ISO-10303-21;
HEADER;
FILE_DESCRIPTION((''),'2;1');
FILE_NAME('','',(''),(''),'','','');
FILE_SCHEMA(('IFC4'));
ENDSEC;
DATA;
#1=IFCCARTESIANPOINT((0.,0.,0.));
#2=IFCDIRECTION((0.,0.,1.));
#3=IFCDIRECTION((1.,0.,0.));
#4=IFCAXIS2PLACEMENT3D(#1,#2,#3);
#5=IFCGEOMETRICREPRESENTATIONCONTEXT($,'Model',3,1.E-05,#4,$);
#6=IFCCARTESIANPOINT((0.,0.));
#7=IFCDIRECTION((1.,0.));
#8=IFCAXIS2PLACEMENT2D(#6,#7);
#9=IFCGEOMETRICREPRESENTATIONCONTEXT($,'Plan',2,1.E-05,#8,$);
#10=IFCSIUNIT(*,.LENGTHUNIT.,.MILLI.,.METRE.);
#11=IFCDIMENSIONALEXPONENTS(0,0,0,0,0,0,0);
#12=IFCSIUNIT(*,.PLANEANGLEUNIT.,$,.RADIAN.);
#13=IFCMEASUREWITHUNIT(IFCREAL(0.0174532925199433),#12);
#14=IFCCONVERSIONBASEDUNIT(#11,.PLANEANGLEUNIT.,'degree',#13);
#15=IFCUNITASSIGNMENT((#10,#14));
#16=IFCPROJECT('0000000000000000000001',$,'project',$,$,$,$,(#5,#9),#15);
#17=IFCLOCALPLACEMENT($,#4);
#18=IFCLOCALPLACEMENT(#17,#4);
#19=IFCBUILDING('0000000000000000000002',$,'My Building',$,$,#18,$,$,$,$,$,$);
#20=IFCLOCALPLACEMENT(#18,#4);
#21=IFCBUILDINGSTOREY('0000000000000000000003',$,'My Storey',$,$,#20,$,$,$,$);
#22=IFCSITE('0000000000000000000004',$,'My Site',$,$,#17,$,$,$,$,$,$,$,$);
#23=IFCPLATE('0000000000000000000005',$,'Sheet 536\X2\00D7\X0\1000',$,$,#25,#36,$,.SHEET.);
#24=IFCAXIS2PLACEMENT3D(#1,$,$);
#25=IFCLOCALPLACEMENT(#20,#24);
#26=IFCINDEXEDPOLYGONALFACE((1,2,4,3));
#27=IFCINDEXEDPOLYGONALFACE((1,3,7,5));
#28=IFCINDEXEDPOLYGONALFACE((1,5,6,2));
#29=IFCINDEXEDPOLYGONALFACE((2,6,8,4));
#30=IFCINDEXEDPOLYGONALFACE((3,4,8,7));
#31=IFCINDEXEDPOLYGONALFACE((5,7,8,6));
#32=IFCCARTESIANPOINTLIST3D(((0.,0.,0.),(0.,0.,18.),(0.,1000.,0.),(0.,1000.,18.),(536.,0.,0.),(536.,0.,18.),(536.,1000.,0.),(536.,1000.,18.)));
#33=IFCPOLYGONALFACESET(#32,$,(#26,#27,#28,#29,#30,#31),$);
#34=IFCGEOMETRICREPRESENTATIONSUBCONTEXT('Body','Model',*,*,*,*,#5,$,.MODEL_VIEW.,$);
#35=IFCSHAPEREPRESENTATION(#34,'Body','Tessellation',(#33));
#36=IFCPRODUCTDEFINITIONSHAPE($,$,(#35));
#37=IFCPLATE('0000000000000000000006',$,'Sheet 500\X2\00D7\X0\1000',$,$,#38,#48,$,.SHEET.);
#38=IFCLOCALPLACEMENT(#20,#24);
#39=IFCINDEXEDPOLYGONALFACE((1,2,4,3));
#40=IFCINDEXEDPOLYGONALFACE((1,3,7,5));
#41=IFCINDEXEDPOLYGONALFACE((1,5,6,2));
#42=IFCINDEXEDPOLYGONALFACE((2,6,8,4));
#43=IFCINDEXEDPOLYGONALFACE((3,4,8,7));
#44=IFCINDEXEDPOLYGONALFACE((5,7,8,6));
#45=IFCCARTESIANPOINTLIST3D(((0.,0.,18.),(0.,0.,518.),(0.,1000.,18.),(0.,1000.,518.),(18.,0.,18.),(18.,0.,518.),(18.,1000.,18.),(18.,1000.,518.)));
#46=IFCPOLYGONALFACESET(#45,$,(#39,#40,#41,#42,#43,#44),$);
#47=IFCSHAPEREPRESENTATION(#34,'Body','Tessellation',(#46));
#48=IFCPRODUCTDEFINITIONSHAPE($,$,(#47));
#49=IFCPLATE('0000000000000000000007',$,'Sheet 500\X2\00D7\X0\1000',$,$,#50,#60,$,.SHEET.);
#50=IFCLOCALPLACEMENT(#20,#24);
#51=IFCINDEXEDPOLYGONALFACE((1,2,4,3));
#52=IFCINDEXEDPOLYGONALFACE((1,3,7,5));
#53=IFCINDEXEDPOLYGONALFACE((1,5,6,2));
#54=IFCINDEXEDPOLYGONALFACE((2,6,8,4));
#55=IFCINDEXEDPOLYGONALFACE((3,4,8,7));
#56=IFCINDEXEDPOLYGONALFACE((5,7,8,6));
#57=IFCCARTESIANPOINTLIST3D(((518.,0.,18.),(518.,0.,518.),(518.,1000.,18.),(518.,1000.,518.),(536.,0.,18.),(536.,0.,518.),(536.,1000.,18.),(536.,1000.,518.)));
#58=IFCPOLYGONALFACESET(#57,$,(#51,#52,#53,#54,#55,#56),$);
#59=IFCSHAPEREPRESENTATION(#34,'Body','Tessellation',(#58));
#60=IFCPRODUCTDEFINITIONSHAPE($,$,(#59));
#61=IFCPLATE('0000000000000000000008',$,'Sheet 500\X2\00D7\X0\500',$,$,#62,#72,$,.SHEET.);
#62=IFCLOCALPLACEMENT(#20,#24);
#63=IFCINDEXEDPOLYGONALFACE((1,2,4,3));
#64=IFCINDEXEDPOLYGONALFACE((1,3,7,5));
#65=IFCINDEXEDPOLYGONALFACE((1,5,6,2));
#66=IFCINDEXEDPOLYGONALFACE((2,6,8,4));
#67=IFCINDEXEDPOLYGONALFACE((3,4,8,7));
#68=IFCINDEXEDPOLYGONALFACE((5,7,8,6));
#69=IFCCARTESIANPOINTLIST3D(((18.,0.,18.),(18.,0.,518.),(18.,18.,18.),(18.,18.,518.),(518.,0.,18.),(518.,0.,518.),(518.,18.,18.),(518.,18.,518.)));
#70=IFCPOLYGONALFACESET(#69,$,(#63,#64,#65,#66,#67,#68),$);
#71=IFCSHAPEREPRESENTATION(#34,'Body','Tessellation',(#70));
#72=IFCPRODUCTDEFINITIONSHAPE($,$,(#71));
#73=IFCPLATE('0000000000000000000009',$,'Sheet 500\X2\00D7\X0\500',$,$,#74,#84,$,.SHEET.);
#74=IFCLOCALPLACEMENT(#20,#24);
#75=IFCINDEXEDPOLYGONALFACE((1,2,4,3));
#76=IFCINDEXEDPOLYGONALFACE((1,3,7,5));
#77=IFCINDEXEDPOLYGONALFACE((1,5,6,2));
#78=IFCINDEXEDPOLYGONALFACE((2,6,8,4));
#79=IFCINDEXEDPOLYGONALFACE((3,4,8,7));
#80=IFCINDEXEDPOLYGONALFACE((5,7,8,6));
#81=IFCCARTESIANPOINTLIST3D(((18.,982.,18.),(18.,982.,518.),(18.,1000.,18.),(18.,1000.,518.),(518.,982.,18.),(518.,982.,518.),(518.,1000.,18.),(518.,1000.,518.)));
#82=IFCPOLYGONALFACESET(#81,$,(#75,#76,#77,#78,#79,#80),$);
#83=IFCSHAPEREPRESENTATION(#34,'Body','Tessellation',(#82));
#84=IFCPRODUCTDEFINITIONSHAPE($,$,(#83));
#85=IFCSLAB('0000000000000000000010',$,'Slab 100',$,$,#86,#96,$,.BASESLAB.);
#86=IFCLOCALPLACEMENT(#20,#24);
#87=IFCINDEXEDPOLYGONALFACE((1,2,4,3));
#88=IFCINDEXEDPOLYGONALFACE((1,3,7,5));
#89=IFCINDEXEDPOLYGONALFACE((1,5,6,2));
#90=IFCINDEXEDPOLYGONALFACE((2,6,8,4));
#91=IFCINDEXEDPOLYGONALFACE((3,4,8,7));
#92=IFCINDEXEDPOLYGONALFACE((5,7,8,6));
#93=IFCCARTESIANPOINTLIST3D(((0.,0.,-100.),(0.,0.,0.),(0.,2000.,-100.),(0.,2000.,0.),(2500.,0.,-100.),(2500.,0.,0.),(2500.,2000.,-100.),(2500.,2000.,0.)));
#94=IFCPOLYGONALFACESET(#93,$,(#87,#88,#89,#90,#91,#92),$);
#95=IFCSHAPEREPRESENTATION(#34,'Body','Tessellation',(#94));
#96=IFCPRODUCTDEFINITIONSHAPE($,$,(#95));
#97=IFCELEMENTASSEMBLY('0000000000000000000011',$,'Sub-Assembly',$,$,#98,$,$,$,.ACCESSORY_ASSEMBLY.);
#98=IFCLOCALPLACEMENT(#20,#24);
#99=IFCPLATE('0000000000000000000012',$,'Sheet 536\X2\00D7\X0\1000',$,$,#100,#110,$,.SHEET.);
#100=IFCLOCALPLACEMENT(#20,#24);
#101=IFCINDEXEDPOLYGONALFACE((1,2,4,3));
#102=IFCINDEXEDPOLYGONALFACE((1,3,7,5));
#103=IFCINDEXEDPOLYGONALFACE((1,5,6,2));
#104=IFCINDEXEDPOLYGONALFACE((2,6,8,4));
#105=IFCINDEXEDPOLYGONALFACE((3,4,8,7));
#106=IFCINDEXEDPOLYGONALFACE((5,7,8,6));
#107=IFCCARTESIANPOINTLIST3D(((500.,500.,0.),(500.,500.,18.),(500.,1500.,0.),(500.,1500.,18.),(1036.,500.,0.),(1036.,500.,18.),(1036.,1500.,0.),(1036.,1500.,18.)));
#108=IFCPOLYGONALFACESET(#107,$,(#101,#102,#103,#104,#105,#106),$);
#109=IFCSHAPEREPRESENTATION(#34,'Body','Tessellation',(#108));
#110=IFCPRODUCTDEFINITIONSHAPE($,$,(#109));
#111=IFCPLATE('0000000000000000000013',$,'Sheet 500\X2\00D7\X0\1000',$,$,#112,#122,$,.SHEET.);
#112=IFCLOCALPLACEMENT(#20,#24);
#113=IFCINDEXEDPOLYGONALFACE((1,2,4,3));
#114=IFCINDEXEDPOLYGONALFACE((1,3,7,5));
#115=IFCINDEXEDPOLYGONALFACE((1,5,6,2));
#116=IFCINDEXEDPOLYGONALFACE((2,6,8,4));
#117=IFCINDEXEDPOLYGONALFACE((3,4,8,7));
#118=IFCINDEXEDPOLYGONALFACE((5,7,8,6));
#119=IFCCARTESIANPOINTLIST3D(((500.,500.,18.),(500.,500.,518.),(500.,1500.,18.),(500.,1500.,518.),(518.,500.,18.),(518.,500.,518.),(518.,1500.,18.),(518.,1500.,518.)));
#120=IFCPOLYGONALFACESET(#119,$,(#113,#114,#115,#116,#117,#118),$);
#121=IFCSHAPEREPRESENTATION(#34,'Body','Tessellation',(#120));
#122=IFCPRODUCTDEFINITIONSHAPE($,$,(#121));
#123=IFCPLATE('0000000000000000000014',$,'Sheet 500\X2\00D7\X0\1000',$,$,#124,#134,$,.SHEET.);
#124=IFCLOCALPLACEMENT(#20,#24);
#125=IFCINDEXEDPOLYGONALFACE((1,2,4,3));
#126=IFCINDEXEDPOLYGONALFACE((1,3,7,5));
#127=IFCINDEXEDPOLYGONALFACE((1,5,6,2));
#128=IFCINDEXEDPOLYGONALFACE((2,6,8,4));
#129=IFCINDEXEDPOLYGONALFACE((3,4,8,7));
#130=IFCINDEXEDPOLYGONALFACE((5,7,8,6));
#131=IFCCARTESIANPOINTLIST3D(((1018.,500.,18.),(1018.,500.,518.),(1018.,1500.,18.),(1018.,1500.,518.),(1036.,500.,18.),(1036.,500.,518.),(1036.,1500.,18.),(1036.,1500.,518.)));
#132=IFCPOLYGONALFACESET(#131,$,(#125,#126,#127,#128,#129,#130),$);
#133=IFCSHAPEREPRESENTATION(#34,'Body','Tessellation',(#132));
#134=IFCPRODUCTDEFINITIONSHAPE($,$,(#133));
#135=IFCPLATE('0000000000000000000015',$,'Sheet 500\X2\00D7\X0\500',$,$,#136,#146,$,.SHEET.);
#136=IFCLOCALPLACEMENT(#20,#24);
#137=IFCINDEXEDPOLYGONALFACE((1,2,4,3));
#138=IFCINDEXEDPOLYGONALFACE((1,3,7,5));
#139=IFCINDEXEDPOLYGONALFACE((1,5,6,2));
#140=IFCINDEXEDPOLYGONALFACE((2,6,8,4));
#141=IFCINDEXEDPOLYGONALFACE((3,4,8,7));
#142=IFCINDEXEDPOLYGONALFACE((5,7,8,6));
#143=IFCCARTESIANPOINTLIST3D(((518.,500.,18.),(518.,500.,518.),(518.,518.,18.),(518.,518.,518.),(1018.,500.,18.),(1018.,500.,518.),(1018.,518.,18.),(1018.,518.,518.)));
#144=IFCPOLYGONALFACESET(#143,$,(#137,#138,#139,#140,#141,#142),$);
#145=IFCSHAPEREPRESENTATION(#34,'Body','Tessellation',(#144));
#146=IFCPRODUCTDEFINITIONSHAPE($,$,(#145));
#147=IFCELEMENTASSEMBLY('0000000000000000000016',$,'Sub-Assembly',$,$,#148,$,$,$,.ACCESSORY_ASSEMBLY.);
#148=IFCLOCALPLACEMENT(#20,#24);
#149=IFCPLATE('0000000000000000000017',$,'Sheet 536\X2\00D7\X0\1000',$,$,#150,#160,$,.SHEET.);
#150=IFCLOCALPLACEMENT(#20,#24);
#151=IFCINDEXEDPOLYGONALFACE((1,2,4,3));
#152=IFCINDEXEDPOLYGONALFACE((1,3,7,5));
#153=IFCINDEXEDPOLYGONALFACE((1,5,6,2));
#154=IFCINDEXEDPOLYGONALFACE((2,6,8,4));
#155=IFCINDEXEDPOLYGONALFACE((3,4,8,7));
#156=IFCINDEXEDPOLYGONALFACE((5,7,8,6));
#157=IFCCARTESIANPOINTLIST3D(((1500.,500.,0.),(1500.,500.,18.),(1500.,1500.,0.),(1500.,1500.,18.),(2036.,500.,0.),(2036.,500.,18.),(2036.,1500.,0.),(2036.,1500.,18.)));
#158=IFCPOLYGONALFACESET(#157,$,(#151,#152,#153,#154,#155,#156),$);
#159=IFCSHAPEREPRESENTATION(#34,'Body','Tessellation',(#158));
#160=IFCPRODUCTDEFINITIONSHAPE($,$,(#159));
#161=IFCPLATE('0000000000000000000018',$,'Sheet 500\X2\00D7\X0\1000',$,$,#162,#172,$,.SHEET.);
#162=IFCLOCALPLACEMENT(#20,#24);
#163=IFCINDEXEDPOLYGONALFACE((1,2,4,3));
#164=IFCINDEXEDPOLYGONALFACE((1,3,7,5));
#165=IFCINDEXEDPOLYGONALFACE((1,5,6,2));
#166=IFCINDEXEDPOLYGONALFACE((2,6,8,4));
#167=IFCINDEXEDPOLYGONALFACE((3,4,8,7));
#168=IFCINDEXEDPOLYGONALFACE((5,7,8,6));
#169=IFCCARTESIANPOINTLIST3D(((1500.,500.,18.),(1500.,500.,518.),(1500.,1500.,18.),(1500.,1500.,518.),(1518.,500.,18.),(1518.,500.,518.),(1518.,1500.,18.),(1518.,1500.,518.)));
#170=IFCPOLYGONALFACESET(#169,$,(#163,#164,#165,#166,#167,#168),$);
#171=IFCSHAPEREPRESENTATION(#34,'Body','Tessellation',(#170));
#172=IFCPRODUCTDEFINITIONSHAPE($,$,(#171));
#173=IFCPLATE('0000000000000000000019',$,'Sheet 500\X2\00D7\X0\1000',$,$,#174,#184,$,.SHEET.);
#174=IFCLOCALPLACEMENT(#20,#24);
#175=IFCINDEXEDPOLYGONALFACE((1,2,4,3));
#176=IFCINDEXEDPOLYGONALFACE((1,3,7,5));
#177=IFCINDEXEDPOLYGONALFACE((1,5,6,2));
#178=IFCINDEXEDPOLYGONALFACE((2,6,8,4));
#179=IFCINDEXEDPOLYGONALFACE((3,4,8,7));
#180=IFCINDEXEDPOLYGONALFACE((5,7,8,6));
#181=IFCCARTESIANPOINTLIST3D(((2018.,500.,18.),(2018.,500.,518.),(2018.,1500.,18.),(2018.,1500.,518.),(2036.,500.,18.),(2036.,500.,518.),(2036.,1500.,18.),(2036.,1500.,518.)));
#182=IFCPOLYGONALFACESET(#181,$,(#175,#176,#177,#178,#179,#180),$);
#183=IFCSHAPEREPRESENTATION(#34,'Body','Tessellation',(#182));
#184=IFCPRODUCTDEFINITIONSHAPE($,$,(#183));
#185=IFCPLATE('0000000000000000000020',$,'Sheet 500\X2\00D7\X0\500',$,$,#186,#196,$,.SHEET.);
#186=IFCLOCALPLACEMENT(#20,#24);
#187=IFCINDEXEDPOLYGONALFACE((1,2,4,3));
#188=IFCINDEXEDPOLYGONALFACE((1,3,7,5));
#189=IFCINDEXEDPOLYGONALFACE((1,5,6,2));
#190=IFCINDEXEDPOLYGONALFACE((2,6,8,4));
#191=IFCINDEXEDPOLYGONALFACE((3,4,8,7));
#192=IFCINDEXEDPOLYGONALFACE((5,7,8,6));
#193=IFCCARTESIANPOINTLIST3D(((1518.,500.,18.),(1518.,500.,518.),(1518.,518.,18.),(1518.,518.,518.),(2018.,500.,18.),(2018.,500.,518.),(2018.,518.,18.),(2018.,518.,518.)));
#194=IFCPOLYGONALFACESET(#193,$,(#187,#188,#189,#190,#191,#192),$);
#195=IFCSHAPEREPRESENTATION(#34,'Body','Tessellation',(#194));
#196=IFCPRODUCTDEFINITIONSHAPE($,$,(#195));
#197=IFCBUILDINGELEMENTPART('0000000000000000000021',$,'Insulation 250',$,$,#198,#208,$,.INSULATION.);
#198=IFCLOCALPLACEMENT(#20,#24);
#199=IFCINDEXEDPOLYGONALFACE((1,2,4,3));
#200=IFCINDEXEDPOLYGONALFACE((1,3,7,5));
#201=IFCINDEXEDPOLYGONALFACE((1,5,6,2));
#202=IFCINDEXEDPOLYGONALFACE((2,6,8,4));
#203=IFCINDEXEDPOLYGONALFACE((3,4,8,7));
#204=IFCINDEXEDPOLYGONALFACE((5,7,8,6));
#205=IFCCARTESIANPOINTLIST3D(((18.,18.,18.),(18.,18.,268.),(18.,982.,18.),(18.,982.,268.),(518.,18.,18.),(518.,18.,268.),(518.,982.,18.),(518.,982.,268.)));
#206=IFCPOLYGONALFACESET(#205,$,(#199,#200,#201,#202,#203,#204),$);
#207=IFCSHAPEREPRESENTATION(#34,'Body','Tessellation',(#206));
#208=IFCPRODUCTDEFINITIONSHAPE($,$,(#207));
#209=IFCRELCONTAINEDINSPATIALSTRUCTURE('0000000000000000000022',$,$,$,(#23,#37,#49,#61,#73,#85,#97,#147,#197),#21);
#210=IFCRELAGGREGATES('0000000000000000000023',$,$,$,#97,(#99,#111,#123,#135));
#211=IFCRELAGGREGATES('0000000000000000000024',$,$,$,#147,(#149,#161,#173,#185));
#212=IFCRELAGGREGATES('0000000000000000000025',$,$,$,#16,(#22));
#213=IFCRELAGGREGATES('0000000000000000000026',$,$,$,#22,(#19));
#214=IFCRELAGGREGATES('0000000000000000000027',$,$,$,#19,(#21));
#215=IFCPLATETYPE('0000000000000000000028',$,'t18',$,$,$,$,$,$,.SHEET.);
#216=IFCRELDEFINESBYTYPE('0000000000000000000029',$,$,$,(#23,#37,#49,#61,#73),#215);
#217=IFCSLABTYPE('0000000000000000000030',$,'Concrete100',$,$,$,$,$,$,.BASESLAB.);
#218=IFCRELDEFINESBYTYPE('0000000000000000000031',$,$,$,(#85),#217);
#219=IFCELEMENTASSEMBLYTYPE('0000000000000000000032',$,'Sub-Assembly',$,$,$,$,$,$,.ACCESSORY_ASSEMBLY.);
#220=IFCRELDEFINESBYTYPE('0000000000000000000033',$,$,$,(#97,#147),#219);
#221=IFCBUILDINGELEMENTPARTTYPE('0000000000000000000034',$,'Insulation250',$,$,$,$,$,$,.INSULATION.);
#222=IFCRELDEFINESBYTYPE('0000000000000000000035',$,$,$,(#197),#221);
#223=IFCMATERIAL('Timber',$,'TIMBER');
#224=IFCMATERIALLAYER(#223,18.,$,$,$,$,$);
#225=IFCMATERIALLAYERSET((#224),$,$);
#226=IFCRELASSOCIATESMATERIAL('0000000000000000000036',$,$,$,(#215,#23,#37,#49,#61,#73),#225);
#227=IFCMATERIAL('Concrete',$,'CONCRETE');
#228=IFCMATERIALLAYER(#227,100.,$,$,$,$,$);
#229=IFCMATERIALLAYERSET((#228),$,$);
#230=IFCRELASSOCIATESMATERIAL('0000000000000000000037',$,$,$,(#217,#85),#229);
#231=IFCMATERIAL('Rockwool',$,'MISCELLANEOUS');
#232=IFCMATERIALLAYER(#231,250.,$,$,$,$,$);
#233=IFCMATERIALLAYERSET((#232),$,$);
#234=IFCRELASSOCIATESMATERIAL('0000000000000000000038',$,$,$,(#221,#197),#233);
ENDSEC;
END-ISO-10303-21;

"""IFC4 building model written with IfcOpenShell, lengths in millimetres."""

from ifc_helpers import new_model, entity, si_unit, converted_unit, frame, origin_with_axes, origin_2d_with_axis, place, context, subcontext, project, spatial, rectangle, extrude, material, layer, layer_set, layer_usage, type_object, element, aggregate, save


model = new_model("IFC4")

# Units and contexts
model_context = context("Model", 3, precision=1e-05, world=origin_with_axes())
plan_context = context("Plan", 2, precision=1e-05, world=origin_2d_with_axis())
body_context = subcontext(model_context, "Body", "Model", "MODEL_VIEW")
ifc_project = project(units=[si_unit("LENGTHUNIT", "METRE", prefix="MILLI"), converted_unit("PLANEANGLEUNIT", "degree", entity("IfcReal", 0.0174532925199433), si_unit("PLANEANGLEUNIT", "RADIAN"), dimensions=[0, 0, 0, 0, 0, 0, 0])], contexts=[model_context, plan_context])

# Site, building, storey
site_placement = place(None, origin_with_axes())
site = spatial("IfcSite", under=ifc_project, at=site_placement, Name="My Site")
building_placement = place(site_placement, origin_with_axes())
building = spatial("IfcBuilding", under=site, at=building_placement, Name="My Building")
storey_placement = place(building_placement, origin_with_axes())
storey = spatial("IfcBuildingStorey", under=building, at=storey_placement, Name="My Storey")

# Plates
ifc_material_1 = material(Name="Timber", Category="TIMBER")
ifc_layer_1 = layer(ifc_material_1, 18.0)
ifc_layer_set_1 = layer_set([ifc_layer_1])
ifc_layer_usage_1 = layer_usage(ifc_layer_set_1, "AXIS3", "POSITIVE", 0.0)
plate_type = type_object("IfcPlateType", Name="t18", PredefinedType="SHEET", material=ifc_layer_set_1)
plate_1_placement = place(storey_placement, frame((268.0, 500.0, 0.0), z_axis=(0.0, 0.0, 1.0), x_axis=(1.0, 0.0, 0.0)))
element("IfcPlate", 1, at=plate_1_placement, inside=storey, type_object=plate_type, material=ifc_layer_usage_1, Name="Sheet 536×1000", PredefinedType="SHEET", context=body_context, shape_type="SweptSolid", body=[
    extrude(rectangle(XDim=536.0, YDim=1000.0), None, (0.0, 0.0, 1.0), 18.0),
])
for number, where, z_axis, x_axis, name in (
    (2, (0.0, 500.0, 268.0), (1.0, 0.0, 0.0), (0.0, 0.0, 1.0), "Sheet 500×1000"),
    (3, (518.0, 500.0, 268.0), (1.0, 0.0, 0.0), (0.0, 0.0, 1.0), "Sheet 500×1000"),
):
    element("IfcPlate", number, at=place(storey_placement, frame(where, z_axis=z_axis, x_axis=x_axis)), inside=storey, type_object=plate_type, material=ifc_layer_usage_1, Name=name, PredefinedType="SHEET", context=body_context, shape_type="SweptSolid", body=[
        extrude(rectangle(XDim=500.0, YDim=1000.0), None, (0.0, 0.0, 1.0), 18.0),
    ])
for number, where, z_axis, x_axis, name in (
    (4, (268.0, 0.0, 268.0), (0.0, 1.0, 0.0), (0.0, 0.0, 1.0), "Sheet 500×500"),
    (5, (268.0, 982.0, 268.0), (0.0, 1.0, 0.0), (0.0, 0.0, 1.0), "Sheet 500×500"),
):
    element("IfcPlate", number, at=place(storey_placement, frame(where, z_axis=z_axis, x_axis=x_axis)), inside=storey, type_object=plate_type, material=ifc_layer_usage_1, Name=name, PredefinedType="SHEET", context=body_context, shape_type="SweptSolid", body=[
        extrude(rectangle(XDim=500.0, YDim=500.0), None, (0.0, 0.0, 1.0), 18.0),
    ])

# Slab
ifc_material_2 = material(Name="Concrete", Category="CONCRETE")
ifc_layer_2 = layer(ifc_material_2, 100.0)
ifc_layer_set_2 = layer_set([ifc_layer_2])
ifc_layer_usage_2 = layer_usage(ifc_layer_set_2, "AXIS3", "POSITIVE", 0.0)
slab_type = type_object("IfcSlabType", Name="Concrete100", PredefinedType="BASESLAB", material=ifc_layer_set_2)
slab_1_placement = place(storey_placement, frame((1250.0, 1000.0, -100.0), z_axis=(0.0, 0.0, 1.0), x_axis=(1.0, 0.0, 0.0)))
element("IfcSlab", 6, at=slab_1_placement, inside=storey, type_object=slab_type, material=ifc_layer_usage_2, Name="Slab 100", PredefinedType="BASESLAB", context=body_context, shape_type="SweptSolid", body=[
    extrude(rectangle(XDim=2500.0, YDim=2000.0), None, (0.0, 0.0, 1.0), 100.0),
])

# Element assemblies, plates
element_assembly_type_1 = type_object("IfcElementAssemblyType", Name="Sub-Assembly", PredefinedType="ACCESSORY_ASSEMBLY")
assembly_1_placement = place(storey_placement, frame((500.0, 500.0, 0.0)))
assembly_1 = element("IfcElementAssembly", 7, at=assembly_1_placement, inside=storey, type_object=element_assembly_type_1, Name="Sub-Assembly", PredefinedType="ACCESSORY_ASSEMBLY")
plate_2_placement = place(assembly_1_placement, frame((268.0, 500.0, 0.0), z_axis=(0.0, 0.0, 1.0), x_axis=(1.0, 0.0, 0.0)))
plate_2 = element("IfcPlate", 8, at=plate_2_placement, Name="Sheet 536×1000", PredefinedType="SHEET", context=body_context, shape_type="SweptSolid", body=[
    extrude(rectangle(XDim=536.0, YDim=1000.0), None, (0.0, 0.0, 1.0), 18.0),
])
plate_3_placement = place(assembly_1_placement, frame((0.0, 500.0, 268.0), z_axis=(1.0, 0.0, 0.0), x_axis=(0.0, 0.0, 1.0)))
plate_3 = element("IfcPlate", 9, at=plate_3_placement, Name="Sheet 500×1000", PredefinedType="SHEET", context=body_context, shape_type="SweptSolid", body=[
    extrude(rectangle(XDim=500.0, YDim=1000.0), None, (0.0, 0.0, 1.0), 18.0),
])
plate_4_placement = place(assembly_1_placement, frame((518.0, 500.0, 268.0), z_axis=(1.0, 0.0, 0.0), x_axis=(0.0, 0.0, 1.0)))
plate_4 = element("IfcPlate", 10, at=plate_4_placement, Name="Sheet 500×1000", PredefinedType="SHEET", context=body_context, shape_type="SweptSolid", body=[
    extrude(rectangle(XDim=500.0, YDim=1000.0), None, (0.0, 0.0, 1.0), 18.0),
])
plate_5_placement = place(assembly_1_placement, frame((268.0, 0.0, 268.0), z_axis=(0.0, 1.0, 0.0), x_axis=(0.0, 0.0, 1.0)))
plate_5 = element("IfcPlate", 11, at=plate_5_placement, Name="Sheet 500×500", PredefinedType="SHEET", context=body_context, shape_type="SweptSolid", body=[
    extrude(rectangle(XDim=500.0, YDim=500.0), None, (0.0, 0.0, 1.0), 18.0),
])
assembly_2_placement = place(storey_placement, frame((1500.0, 500.0, 0.0)))
assembly_2 = element("IfcElementAssembly", 12, at=assembly_2_placement, inside=storey, type_object=element_assembly_type_1, Name="Sub-Assembly", PredefinedType="ACCESSORY_ASSEMBLY")
plate_6_placement = place(assembly_2_placement, frame((268.0, 500.0, 0.0), z_axis=(0.0, 0.0, 1.0), x_axis=(1.0, 0.0, 0.0)))
plate_6 = element("IfcPlate", 13, at=plate_6_placement, Name="Sheet 536×1000", PredefinedType="SHEET", context=body_context, shape_type="SweptSolid", body=[
    extrude(rectangle(XDim=536.0, YDim=1000.0), None, (0.0, 0.0, 1.0), 18.0),
])
plate_7_placement = place(assembly_2_placement, frame((0.0, 500.0, 268.0), z_axis=(1.0, 0.0, 0.0), x_axis=(0.0, 0.0, 1.0)))
plate_7 = element("IfcPlate", 14, at=plate_7_placement, Name="Sheet 500×1000", PredefinedType="SHEET", context=body_context, shape_type="SweptSolid", body=[
    extrude(rectangle(XDim=500.0, YDim=1000.0), None, (0.0, 0.0, 1.0), 18.0),
])
plate_8_placement = place(assembly_2_placement, frame((518.0, 500.0, 268.0), z_axis=(1.0, 0.0, 0.0), x_axis=(0.0, 0.0, 1.0)))
plate_8 = element("IfcPlate", 15, at=plate_8_placement, Name="Sheet 500×1000", PredefinedType="SHEET", context=body_context, shape_type="SweptSolid", body=[
    extrude(rectangle(XDim=500.0, YDim=1000.0), None, (0.0, 0.0, 1.0), 18.0),
])
plate_9_placement = place(assembly_2_placement, frame((268.0, 0.0, 268.0), z_axis=(0.0, 1.0, 0.0), x_axis=(0.0, 0.0, 1.0)))
plate_9 = element("IfcPlate", 16, at=plate_9_placement, Name="Sheet 500×500", PredefinedType="SHEET", context=body_context, shape_type="SweptSolid", body=[
    extrude(rectangle(XDim=500.0, YDim=500.0), None, (0.0, 0.0, 1.0), 18.0),
])

# Building element part
ifc_material_3 = material(Name="Rockwool", Category="MISCELLANEOUS")
ifc_layer_3 = layer(ifc_material_3, 250.0)
ifc_layer_set_3 = layer_set([ifc_layer_3])
ifc_layer_usage_3 = layer_usage(ifc_layer_set_3, "AXIS2", "POSITIVE", 0.0)
building_element_part_type = type_object("IfcBuildingElementPartType", Name="Insulation250", PredefinedType="INSULATION", material=ifc_layer_set_3)
building_element_part_1_placement = place(storey_placement, frame((268.0, 500.0, 18.0), z_axis=(0.0, 0.0, 1.0), x_axis=(1.0, 0.0, 0.0)))
element("IfcBuildingElementPart", 17, at=building_element_part_1_placement, inside=storey, type_object=building_element_part_type, material=ifc_layer_usage_3, Name="Insulation 250", PredefinedType="INSULATION", context=body_context, shape_type="SweptSolid", body=[
    extrude(rectangle(XDim=500.0, YDim=964.0), None, (0.0, 0.0, 1.0), 250.0),
])
aggregate(assembly_1, [plate_2, plate_3, plate_4, plate_5])
aggregate(assembly_2, [plate_6, plate_7, plate_8, plate_9])

save(model, "model.ifc")
